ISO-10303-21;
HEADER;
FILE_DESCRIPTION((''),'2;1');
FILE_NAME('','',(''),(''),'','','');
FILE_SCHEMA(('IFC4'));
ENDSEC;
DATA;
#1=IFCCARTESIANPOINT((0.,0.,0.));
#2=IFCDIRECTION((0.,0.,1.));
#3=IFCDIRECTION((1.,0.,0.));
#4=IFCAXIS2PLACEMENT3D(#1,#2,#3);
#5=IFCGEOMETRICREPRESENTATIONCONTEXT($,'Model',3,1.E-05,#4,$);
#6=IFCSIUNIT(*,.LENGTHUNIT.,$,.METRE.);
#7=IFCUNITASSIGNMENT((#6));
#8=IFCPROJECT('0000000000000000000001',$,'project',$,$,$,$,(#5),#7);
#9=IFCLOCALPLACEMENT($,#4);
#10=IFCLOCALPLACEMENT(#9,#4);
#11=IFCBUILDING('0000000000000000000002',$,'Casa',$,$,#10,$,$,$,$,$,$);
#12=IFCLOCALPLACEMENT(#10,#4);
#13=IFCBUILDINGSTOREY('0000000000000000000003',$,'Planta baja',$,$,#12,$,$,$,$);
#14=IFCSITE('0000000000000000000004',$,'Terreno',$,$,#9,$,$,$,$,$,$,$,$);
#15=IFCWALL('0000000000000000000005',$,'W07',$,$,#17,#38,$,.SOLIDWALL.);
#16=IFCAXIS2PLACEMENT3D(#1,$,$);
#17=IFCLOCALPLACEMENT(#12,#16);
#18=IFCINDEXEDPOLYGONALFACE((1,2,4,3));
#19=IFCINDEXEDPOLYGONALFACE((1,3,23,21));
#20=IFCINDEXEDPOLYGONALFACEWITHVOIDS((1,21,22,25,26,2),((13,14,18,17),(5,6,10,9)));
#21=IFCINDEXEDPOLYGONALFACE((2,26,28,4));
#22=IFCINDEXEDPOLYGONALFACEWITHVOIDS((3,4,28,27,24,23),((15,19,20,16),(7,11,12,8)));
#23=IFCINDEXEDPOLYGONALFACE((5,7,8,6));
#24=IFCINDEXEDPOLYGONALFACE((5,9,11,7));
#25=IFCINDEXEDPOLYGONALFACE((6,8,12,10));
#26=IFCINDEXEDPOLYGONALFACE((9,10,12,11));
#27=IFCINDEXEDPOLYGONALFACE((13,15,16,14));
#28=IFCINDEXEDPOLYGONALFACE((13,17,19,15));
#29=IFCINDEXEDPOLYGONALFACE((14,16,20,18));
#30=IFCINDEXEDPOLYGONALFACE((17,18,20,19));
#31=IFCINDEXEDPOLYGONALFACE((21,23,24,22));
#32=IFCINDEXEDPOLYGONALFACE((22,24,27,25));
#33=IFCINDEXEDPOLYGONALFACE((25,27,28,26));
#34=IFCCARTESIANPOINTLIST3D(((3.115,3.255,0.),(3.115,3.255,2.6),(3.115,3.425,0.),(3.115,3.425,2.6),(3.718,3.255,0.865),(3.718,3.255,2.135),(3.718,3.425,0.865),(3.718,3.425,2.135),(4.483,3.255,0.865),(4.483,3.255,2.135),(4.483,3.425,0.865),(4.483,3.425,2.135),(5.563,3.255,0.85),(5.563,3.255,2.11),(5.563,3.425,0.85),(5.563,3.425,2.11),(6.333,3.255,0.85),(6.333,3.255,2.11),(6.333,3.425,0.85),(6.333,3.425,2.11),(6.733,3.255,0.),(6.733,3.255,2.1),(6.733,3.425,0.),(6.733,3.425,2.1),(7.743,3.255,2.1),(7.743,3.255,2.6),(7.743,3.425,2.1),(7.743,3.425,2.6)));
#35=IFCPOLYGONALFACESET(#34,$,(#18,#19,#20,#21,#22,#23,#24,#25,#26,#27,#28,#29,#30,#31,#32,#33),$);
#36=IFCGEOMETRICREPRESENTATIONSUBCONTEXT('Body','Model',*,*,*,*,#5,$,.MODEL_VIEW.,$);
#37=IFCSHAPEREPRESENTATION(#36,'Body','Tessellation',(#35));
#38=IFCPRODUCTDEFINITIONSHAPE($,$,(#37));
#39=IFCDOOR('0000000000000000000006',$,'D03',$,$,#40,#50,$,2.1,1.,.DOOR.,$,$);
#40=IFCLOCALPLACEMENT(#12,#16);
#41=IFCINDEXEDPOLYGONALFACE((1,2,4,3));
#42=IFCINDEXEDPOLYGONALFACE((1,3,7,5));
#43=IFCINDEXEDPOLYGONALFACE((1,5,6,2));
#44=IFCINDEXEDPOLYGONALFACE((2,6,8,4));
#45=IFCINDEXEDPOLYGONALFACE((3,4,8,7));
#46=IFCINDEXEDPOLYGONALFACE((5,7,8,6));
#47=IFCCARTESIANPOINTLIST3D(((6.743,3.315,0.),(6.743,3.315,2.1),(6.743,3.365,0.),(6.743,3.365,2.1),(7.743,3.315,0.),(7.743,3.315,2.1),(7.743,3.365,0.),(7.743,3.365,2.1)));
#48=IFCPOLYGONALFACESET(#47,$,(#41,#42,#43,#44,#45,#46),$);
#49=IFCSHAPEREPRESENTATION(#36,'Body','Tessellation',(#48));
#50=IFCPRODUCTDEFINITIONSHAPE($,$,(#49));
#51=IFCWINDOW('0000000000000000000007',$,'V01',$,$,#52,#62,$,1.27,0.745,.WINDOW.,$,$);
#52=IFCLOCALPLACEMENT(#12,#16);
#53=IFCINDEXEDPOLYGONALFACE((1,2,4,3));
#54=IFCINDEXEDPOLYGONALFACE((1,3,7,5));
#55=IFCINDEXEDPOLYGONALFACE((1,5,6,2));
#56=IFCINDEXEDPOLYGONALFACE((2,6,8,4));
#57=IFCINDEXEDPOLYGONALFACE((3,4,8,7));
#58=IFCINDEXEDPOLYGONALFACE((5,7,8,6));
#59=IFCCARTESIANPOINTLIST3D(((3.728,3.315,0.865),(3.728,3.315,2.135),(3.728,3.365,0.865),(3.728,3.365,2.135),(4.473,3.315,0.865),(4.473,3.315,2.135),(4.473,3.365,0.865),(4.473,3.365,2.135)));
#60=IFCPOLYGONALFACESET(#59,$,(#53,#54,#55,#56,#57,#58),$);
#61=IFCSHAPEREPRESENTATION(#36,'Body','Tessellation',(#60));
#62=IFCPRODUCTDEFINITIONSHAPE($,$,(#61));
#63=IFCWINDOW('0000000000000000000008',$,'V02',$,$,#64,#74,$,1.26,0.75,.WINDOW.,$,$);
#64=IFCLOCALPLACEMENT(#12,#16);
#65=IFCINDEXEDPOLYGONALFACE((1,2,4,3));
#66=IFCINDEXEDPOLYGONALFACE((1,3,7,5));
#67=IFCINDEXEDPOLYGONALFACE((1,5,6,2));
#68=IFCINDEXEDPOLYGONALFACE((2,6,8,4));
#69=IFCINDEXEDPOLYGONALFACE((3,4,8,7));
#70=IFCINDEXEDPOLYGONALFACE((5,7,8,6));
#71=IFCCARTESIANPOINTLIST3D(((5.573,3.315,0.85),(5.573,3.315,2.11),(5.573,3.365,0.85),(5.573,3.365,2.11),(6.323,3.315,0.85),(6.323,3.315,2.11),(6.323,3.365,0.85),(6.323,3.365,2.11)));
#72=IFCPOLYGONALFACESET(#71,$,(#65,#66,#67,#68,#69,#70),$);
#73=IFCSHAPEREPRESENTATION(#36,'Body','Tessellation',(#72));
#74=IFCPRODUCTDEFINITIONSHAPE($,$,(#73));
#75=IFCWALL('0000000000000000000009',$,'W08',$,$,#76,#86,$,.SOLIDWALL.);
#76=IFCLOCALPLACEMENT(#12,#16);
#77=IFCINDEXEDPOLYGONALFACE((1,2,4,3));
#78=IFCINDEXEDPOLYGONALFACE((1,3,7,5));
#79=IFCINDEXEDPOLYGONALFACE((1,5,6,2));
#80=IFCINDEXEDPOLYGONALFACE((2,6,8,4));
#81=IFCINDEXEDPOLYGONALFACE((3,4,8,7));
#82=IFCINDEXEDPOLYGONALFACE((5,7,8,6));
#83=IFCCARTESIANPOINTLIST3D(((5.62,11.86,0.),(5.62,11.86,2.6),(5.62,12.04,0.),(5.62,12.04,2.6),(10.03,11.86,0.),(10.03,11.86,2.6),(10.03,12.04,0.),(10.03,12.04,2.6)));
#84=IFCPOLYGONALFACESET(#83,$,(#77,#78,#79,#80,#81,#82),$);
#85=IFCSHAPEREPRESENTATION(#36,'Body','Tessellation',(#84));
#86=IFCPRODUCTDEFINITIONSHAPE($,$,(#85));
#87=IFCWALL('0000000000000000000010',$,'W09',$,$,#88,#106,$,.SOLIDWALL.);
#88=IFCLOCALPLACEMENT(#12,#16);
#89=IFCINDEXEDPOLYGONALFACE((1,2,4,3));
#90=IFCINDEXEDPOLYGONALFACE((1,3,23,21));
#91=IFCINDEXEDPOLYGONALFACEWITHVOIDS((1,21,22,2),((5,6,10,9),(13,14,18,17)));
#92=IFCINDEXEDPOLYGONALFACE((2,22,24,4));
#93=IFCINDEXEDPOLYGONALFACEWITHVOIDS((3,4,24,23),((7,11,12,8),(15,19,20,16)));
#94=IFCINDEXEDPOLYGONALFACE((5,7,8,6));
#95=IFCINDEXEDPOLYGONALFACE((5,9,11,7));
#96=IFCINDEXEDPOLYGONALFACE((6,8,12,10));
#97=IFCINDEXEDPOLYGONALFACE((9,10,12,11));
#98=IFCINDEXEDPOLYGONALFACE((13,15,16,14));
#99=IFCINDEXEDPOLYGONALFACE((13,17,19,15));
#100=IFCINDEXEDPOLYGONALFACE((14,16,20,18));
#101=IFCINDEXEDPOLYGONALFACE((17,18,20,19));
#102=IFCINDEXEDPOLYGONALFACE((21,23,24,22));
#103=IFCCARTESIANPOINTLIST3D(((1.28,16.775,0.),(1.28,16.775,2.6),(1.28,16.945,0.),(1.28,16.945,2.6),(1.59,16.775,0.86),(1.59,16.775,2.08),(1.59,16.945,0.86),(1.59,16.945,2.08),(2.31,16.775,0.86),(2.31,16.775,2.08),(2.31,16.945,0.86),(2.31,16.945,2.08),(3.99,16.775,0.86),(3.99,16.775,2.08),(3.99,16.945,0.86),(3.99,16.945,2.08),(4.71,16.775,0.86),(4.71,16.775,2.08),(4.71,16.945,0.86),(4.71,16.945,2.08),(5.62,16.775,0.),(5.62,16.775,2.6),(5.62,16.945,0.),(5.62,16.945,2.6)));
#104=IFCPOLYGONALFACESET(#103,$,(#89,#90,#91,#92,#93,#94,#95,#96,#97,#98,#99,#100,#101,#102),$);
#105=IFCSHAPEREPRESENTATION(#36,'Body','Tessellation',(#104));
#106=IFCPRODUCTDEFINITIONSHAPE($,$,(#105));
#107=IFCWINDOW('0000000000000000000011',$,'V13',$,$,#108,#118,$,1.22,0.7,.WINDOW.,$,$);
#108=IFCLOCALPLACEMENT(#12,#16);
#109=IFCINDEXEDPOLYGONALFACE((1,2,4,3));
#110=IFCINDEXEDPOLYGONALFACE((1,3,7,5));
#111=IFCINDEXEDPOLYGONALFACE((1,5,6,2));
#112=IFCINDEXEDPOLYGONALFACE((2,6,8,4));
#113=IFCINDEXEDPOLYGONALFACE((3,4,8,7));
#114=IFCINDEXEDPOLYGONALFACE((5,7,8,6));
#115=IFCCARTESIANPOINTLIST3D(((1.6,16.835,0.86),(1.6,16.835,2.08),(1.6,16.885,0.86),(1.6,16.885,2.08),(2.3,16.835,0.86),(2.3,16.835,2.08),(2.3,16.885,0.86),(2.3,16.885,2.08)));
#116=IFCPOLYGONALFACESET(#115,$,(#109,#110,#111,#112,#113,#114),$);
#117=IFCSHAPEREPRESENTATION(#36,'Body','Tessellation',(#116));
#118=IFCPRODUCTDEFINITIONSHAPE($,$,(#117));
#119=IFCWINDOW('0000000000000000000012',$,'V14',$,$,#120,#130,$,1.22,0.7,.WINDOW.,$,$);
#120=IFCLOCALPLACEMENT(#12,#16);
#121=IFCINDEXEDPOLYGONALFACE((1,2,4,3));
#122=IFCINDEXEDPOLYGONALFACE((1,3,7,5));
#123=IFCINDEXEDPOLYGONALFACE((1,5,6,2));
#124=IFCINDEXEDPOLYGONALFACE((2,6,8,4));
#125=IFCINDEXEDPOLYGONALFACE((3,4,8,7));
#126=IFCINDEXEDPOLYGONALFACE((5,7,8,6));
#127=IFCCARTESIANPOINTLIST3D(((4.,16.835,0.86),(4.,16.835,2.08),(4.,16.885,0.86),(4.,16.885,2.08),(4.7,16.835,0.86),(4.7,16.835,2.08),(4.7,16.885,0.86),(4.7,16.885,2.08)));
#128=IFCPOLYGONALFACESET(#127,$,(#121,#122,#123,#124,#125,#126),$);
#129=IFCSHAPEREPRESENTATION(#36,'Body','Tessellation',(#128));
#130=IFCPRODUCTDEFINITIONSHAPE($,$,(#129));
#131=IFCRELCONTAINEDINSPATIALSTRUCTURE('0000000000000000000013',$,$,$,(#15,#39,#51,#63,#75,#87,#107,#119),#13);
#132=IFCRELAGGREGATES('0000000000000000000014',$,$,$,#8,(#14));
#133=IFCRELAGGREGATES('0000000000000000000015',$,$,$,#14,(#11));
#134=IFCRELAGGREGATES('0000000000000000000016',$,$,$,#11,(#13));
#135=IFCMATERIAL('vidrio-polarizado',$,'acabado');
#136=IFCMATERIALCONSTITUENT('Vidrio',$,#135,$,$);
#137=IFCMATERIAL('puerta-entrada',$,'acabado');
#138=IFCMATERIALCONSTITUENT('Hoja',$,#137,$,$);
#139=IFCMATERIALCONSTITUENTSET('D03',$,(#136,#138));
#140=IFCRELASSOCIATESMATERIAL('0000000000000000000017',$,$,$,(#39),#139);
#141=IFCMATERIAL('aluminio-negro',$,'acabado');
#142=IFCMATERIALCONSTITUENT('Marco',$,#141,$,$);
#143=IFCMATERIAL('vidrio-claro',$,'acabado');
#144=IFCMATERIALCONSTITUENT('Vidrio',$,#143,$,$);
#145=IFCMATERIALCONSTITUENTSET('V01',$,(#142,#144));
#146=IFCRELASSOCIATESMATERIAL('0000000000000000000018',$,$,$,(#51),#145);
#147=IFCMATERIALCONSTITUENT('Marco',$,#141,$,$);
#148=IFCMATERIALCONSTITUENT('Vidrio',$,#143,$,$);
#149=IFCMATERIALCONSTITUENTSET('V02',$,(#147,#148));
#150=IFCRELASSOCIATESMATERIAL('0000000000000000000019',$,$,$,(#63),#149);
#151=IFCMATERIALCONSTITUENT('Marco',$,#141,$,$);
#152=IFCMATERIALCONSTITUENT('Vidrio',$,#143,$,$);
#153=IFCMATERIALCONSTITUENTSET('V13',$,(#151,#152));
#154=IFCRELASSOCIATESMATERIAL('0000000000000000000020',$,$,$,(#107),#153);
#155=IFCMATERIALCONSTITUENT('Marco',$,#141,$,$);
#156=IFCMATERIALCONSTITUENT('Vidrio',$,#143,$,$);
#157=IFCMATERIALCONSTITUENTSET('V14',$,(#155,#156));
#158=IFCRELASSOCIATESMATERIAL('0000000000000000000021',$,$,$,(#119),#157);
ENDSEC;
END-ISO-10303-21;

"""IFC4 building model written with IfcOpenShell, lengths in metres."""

from ifc_helpers import new_model, si_unit, frame, origin_with_axes, place, context, subcontext, project, spatial, line, indexed_curve, outline, extrude, material, constituent, constituent_set, element, fill, save


model = new_model("IFC4")

# Units and contexts
model_context = context("Model", 3, precision=1e-05, world=origin_with_axes())
body_context = subcontext(model_context, "Body", "Model", "MODEL_VIEW")
ifc_project = project(units=[si_unit("LENGTHUNIT", "METRE")], contexts=[model_context])

# Site, building, storey
site_placement = place(None, origin_with_axes())
site = spatial("IfcSite", under=ifc_project, at=site_placement, Name="Terreno")
building_placement = place(site_placement, origin_with_axes())
building = spatial("IfcBuilding", under=site, at=building_placement, Name="Casa")
storey_placement = place(building_placement, origin_with_axes())
storey = spatial("IfcBuildingStorey", under=building, at=storey_placement, Name="Planta baja")

# Wall, openings, door, windows
wall_1_placement = place(storey_placement, origin_with_axes())
wall_1 = element("IfcWall", 1, at=wall_1_placement, inside=storey, Name="W07", PredefinedType="SOLIDWALL", context=body_context, shape_type="SweptSolid", body=[
    extrude(outline(indexed_curve([(3.115, 3.425), (7.743, 3.425), (7.743, 3.255), (3.115, 3.255)], segments=[line(1, 2, 3, 4, 1)])), origin_with_axes(), (0.0, 0.0, 1.0), 2.6),
])
opening_1_placement = place(wall_1_placement, origin_with_axes())
opening_1 = element("IfcOpeningElement", 2, at=opening_1_placement, cuts=wall_1, PredefinedType="OPENING", context=body_context, shape_type="SweptSolid", body=[
    extrude(outline(indexed_curve([(6.733, 3.245), (7.753, 3.245), (7.753, 3.435), (6.733, 3.435)], segments=[line(1, 2, 3, 4, 1)])), origin_with_axes(), (0.0, 0.0, 1.0), 2.1),
])
opening_2_placement = place(wall_1_placement, origin_with_axes())
opening_2 = element("IfcOpeningElement", 3, at=opening_2_placement, cuts=wall_1, PredefinedType="OPENING", context=body_context, shape_type="SweptSolid", body=[
    extrude(outline(indexed_curve([(3.718, 3.245), (4.483, 3.245), (4.483, 3.435), (3.718, 3.435)], segments=[line(1, 2, 3, 4, 1)])), frame((0.0, 0.0, 0.865), z_axis=(0.0, 0.0, 1.0), x_axis=(1.0, 0.0, 0.0)), (0.0, 0.0, 1.0), 1.27),
])
opening_3_placement = place(wall_1_placement, origin_with_axes())
opening_3 = element("IfcOpeningElement", 4, at=opening_3_placement, cuts=wall_1, PredefinedType="OPENING", context=body_context, shape_type="SweptSolid", body=[
    extrude(outline(indexed_curve([(5.563, 3.245), (6.333, 3.245), (6.333, 3.435), (5.563, 3.435)], segments=[line(1, 2, 3, 4, 1)])), frame((0.0, 0.0, 0.85), z_axis=(0.0, 0.0, 1.0), x_axis=(1.0, 0.0, 0.0)), (0.0, 0.0, 1.0), 1.26),
])
ifc_material_1 = material(Name="vidrio-polarizado", Category="acabado")
ifc_constituent_1 = constituent(ifc_material_1, Name="Vidrio")
ifc_material_2 = material(Name="puerta-entrada", Category="acabado")
ifc_constituent_2 = constituent(ifc_material_2, Name="Hoja")
ifc_constituent_set_1 = constituent_set(constituents=[ifc_constituent_1, ifc_constituent_2], Name="D03")
door_1_placement = place(opening_1_placement, origin_with_axes())
door_1 = element("IfcDoor", 5, at=door_1_placement, inside=storey, material=ifc_constituent_set_1, Name="D03", OverallHeight=2.1, OverallWidth=1.0, PredefinedType="DOOR", context=body_context, shape_type="SweptSolid", body=[
    extrude(outline(indexed_curve([(6.743, 3.315), (7.743, 3.315), (7.743, 3.365), (6.743, 3.365)], segments=[line(1, 2, 3, 4, 1)])), origin_with_axes(), (0.0, 0.0, 1.0), 2.1),
])
fill(opening_1, door_1)
ifc_material_3 = material(Name="aluminio-negro", Category="acabado")
ifc_constituent_3 = constituent(ifc_material_3, Name="Marco")
ifc_material_4 = material(Name="vidrio-claro", Category="acabado")
ifc_constituent_4 = constituent(ifc_material_4, Name="Vidrio")
ifc_constituent_set_2 = constituent_set(constituents=[ifc_constituent_3, ifc_constituent_4], Name="V01")
window_1_placement = place(opening_2_placement, origin_with_axes())
window_1 = element("IfcWindow", 6, at=window_1_placement, inside=storey, material=ifc_constituent_set_2, Name="V01", OverallHeight=1.27, OverallWidth=0.745, PredefinedType="WINDOW", context=body_context, shape_type="SweptSolid", body=[
    extrude(outline(indexed_curve([(3.728, 3.315), (4.473, 3.315), (4.473, 3.365), (3.728, 3.365)], segments=[line(1, 2, 3, 4, 1)])), frame((0.0, 0.0, 0.865), z_axis=(0.0, 0.0, 1.0), x_axis=(1.0, 0.0, 0.0)), (0.0, 0.0, 1.0), 1.27),
])
fill(opening_2, window_1)
ifc_constituent_5 = constituent(ifc_material_3, Name="Marco")
ifc_constituent_6 = constituent(ifc_material_4, Name="Vidrio")
ifc_constituent_set_3 = constituent_set(constituents=[ifc_constituent_5, ifc_constituent_6], Name="V02")
window_2_placement = place(opening_3_placement, origin_with_axes())
window_2 = element("IfcWindow", 7, at=window_2_placement, inside=storey, material=ifc_constituent_set_3, Name="V02", OverallHeight=1.26, OverallWidth=0.75, PredefinedType="WINDOW", context=body_context, shape_type="SweptSolid", body=[
    extrude(outline(indexed_curve([(5.573, 3.315), (6.323, 3.315), (6.323, 3.365), (5.573, 3.365)], segments=[line(1, 2, 3, 4, 1)])), frame((0.0, 0.0, 0.85), z_axis=(0.0, 0.0, 1.0), x_axis=(1.0, 0.0, 0.0)), (0.0, 0.0, 1.0), 1.26),
])
fill(opening_3, window_2)

# Wall
wall_2_placement = place(storey_placement, origin_with_axes())
element("IfcWall", 8, at=wall_2_placement, inside=storey, Name="W08", PredefinedType="SOLIDWALL", context=body_context, shape_type="SweptSolid", body=[
    extrude(outline(indexed_curve([(5.62, 11.86), (5.62, 12.04), (10.03, 12.04), (10.03, 11.86)], segments=[line(1, 2, 3, 4, 1)])), origin_with_axes(), (0.0, 0.0, 1.0), 2.6),
])

# Wall, openings, windows
wall_3_placement = place(storey_placement, origin_with_axes())
wall_3 = element("IfcWall", 9, at=wall_3_placement, inside=storey, Name="W09", PredefinedType="SOLIDWALL", context=body_context, shape_type="SweptSolid", body=[
    extrude(outline(indexed_curve([(1.28, 16.775), (1.28, 16.945), (5.62, 16.945), (5.62, 16.775)], segments=[line(1, 2, 3, 4, 1)])), origin_with_axes(), (0.0, 0.0, 1.0), 2.6),
])
opening_4_placement = place(wall_3_placement, origin_with_axes())
opening_4 = element("IfcOpeningElement", 10, at=opening_4_placement, cuts=wall_3, PredefinedType="OPENING", context=body_context, shape_type="SweptSolid", body=[
    extrude(outline(indexed_curve([(1.59, 16.765), (2.31, 16.765), (2.31, 16.955), (1.59, 16.955)], segments=[line(1, 2, 3, 4, 1)])), frame((0.0, 0.0, 0.86), z_axis=(0.0, 0.0, 1.0), x_axis=(1.0, 0.0, 0.0)), (0.0, 0.0, 1.0), 1.22),
])
opening_5_placement = place(wall_3_placement, origin_with_axes())
opening_5 = element("IfcOpeningElement", 11, at=opening_5_placement, cuts=wall_3, PredefinedType="OPENING", context=body_context, shape_type="SweptSolid", body=[
    extrude(outline(indexed_curve([(3.99, 16.765), (4.71, 16.765), (4.71, 16.955), (3.99, 16.955)], segments=[line(1, 2, 3, 4, 1)])), frame((0.0, 0.0, 0.86), z_axis=(0.0, 0.0, 1.0), x_axis=(1.0, 0.0, 0.0)), (0.0, 0.0, 1.0), 1.22),
])
ifc_constituent_7 = constituent(ifc_material_3, Name="Marco")
ifc_constituent_8 = constituent(ifc_material_4, Name="Vidrio")
ifc_constituent_set_4 = constituent_set(constituents=[ifc_constituent_7, ifc_constituent_8], Name="V13")
window_3_placement = place(opening_4_placement, origin_with_axes())
window_3 = element("IfcWindow", 12, at=window_3_placement, inside=storey, material=ifc_constituent_set_4, Name="V13", OverallHeight=1.22, OverallWidth=0.7, PredefinedType="WINDOW", context=body_context, shape_type="SweptSolid", body=[
    extrude(outline(indexed_curve([(1.6, 16.835), (2.3, 16.835), (2.3, 16.885), (1.6, 16.885)], segments=[line(1, 2, 3, 4, 1)])), frame((0.0, 0.0, 0.86), z_axis=(0.0, 0.0, 1.0), x_axis=(1.0, 0.0, 0.0)), (0.0, 0.0, 1.0), 1.22),
])
fill(opening_4, window_3)
ifc_constituent_9 = constituent(ifc_material_3, Name="Marco")
ifc_constituent_10 = constituent(ifc_material_4, Name="Vidrio")
ifc_constituent_set_5 = constituent_set(constituents=[ifc_constituent_9, ifc_constituent_10], Name="V14")
window_4_placement = place(opening_5_placement, origin_with_axes())
window_4 = element("IfcWindow", 13, at=window_4_placement, inside=storey, material=ifc_constituent_set_5, Name="V14", OverallHeight=1.22, OverallWidth=0.7, PredefinedType="WINDOW", context=body_context, shape_type="SweptSolid", body=[
    extrude(outline(indexed_curve([(4.0, 16.835), (4.7, 16.835), (4.7, 16.885), (4.0, 16.885)], segments=[line(1, 2, 3, 4, 1)])), frame((0.0, 0.0, 0.86), z_axis=(0.0, 0.0, 1.0), x_axis=(1.0, 0.0, 0.0)), (0.0, 0.0, 1.0), 1.22),
])
fill(opening_5, window_4)

save(model, "model.ifc")
